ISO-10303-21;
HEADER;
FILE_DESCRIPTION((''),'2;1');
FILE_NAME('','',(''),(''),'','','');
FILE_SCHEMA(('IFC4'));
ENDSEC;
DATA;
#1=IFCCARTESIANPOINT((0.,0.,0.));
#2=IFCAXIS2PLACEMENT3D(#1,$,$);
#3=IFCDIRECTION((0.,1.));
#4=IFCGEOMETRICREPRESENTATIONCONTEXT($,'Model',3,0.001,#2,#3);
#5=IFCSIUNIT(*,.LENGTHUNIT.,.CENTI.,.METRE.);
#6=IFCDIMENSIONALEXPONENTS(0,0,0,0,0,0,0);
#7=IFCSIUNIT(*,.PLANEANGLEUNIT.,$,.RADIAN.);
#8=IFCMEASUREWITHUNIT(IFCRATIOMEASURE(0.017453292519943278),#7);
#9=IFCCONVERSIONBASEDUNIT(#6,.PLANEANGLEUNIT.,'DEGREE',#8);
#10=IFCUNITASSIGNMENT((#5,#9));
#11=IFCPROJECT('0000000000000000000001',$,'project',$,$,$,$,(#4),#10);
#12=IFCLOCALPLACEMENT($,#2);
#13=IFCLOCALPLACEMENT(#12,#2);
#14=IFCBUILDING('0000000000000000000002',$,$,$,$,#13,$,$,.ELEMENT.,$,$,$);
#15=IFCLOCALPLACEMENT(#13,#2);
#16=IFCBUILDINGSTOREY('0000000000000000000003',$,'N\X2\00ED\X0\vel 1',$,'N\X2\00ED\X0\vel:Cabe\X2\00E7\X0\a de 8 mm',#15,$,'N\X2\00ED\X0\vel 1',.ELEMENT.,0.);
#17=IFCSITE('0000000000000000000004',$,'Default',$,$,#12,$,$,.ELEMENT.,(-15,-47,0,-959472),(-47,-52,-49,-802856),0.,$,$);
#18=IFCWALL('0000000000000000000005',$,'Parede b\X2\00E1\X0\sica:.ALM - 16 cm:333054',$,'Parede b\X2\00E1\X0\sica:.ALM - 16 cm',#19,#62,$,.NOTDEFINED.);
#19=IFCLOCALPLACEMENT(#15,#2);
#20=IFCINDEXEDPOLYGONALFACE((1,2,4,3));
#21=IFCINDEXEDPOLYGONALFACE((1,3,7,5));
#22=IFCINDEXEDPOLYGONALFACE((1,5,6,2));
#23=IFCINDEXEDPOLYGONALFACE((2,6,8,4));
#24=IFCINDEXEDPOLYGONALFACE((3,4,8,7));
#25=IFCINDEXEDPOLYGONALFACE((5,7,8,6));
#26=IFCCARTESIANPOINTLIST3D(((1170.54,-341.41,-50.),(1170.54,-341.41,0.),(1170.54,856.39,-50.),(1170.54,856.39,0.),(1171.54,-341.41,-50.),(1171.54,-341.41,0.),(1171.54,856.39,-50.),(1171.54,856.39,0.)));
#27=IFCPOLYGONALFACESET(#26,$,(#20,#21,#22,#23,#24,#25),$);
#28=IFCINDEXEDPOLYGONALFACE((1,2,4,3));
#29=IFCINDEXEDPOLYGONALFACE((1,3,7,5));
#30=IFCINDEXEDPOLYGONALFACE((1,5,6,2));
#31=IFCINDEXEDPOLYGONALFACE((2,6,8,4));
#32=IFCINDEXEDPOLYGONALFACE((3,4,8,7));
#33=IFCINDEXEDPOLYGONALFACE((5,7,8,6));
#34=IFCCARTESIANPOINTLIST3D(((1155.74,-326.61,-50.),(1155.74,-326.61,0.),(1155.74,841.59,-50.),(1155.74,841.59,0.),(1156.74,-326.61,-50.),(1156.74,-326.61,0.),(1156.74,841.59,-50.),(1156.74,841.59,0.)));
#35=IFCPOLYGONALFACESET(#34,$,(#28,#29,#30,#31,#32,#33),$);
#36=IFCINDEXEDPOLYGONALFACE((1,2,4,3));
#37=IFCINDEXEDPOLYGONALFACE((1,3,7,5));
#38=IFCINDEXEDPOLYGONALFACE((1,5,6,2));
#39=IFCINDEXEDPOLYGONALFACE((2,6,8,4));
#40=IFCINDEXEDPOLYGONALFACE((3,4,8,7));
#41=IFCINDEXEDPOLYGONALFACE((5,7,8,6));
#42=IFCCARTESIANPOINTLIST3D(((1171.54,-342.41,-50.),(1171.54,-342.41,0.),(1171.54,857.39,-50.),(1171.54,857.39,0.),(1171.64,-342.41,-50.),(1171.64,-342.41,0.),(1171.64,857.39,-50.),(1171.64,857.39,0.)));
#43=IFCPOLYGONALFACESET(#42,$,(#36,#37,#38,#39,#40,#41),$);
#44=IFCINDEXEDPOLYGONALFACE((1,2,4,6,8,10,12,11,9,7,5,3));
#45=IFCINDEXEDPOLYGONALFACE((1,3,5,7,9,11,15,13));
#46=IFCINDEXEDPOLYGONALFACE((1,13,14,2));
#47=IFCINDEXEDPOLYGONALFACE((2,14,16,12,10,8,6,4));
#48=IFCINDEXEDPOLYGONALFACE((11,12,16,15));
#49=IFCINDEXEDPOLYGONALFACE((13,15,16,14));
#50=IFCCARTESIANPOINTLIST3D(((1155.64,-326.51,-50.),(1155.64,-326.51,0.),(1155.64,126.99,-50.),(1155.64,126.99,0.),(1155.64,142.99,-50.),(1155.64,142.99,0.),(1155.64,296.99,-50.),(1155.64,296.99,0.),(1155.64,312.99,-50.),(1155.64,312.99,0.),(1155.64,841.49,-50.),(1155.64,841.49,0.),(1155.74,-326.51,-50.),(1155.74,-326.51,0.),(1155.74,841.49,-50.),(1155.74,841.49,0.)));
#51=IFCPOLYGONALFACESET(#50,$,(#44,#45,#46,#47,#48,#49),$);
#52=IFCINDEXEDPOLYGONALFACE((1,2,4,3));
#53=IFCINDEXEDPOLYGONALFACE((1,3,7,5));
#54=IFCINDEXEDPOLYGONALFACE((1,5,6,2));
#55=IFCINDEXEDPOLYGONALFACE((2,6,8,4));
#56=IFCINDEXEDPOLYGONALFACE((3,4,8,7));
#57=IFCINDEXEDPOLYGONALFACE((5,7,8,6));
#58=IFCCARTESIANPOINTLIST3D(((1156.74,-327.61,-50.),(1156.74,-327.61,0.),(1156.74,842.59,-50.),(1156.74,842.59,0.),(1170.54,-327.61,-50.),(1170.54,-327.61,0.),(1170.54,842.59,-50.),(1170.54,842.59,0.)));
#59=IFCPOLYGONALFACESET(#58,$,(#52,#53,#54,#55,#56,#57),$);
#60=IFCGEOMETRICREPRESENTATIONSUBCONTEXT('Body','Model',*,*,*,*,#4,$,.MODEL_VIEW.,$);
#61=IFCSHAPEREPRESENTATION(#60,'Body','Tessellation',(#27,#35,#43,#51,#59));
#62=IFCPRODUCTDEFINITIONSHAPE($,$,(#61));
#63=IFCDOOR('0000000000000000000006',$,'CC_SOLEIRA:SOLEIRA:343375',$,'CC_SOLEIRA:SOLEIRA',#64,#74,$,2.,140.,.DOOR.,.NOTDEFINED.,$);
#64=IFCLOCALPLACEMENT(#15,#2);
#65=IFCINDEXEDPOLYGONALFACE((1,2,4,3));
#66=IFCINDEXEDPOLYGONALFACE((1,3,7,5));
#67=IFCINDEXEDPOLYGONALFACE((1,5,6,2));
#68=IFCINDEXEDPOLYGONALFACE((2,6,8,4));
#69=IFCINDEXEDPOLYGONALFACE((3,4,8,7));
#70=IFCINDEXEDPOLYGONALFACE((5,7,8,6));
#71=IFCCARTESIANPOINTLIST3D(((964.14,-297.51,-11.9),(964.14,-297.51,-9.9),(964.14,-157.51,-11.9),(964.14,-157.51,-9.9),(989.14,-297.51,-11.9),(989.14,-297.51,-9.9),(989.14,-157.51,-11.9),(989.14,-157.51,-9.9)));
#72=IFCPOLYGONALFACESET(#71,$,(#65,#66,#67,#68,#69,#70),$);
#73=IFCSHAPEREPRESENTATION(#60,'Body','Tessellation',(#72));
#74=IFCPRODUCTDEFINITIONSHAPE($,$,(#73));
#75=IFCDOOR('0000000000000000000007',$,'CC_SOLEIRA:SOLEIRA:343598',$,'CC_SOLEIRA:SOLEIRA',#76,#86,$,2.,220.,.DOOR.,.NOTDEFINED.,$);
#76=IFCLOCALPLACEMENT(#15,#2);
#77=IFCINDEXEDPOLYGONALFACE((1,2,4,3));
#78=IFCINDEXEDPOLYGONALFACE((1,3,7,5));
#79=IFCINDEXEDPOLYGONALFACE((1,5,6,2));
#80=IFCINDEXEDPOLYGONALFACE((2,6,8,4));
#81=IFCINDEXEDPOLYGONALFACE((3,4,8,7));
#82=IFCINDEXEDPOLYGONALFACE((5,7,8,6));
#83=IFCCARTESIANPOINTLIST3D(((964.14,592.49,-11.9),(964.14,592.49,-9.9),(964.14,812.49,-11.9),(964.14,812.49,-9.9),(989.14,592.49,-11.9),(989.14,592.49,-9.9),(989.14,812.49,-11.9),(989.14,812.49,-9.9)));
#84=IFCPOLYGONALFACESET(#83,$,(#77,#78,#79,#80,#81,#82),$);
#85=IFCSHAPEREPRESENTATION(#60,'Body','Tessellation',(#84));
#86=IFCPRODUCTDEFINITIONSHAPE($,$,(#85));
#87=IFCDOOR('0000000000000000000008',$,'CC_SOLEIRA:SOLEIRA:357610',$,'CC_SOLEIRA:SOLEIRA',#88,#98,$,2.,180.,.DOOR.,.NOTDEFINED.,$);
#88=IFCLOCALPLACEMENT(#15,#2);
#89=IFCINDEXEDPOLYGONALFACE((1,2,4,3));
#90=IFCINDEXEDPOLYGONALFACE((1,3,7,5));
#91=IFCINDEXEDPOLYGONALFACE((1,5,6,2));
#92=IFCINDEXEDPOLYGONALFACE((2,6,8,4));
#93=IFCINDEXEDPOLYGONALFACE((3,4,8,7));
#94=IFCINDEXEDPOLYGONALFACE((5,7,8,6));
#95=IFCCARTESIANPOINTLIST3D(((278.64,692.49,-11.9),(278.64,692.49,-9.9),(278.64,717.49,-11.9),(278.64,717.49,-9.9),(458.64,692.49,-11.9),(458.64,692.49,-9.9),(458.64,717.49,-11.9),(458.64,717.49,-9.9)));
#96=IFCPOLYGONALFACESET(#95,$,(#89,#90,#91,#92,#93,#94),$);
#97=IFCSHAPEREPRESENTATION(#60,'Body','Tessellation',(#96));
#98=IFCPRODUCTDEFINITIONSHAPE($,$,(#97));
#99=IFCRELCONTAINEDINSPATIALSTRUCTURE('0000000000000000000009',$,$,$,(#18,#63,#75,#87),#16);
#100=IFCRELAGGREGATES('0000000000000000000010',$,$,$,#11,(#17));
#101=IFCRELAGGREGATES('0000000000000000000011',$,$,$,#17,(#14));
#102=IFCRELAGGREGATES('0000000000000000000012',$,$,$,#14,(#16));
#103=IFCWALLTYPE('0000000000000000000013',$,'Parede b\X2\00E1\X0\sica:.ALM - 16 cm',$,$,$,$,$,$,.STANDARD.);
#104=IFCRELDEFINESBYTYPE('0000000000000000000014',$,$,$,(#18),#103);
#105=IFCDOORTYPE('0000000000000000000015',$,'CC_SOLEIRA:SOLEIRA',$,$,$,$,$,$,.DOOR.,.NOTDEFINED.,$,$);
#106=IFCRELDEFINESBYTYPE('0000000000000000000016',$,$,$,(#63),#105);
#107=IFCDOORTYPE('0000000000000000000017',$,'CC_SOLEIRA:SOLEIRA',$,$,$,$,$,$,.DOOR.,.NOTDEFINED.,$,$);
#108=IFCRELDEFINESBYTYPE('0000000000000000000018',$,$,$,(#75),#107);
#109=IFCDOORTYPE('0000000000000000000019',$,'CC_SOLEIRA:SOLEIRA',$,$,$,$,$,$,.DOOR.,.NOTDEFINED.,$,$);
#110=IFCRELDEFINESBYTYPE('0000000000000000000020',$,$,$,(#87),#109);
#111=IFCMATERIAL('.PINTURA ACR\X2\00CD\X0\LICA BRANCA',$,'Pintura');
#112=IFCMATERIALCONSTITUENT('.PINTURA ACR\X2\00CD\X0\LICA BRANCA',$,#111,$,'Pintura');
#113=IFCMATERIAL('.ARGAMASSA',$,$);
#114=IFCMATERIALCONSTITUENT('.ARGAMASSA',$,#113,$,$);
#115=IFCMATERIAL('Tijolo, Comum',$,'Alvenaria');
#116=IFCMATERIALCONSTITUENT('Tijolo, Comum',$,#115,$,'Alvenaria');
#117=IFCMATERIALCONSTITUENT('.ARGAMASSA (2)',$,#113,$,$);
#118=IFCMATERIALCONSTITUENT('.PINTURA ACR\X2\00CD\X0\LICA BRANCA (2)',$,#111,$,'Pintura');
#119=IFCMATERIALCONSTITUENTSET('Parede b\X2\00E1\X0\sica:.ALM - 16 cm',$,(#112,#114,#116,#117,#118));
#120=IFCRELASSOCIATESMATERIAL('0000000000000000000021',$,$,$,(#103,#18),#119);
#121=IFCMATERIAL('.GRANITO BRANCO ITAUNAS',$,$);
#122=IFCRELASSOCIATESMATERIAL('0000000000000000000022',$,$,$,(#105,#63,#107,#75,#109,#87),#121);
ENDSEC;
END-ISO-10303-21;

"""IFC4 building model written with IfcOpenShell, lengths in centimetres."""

from ifc_helpers import new_model, entity, si_unit, converted_unit, direction, frame, origin, place, context, subcontext, project, spatial, indexed_curve, outline, extrude, source, transform, mapped, material, constituent, constituent_set, type_object, type_shapes, element, save


model = new_model("IFC4")

# Units and contexts
model_context = context("Model", 3, precision=0.001, world=origin(), true_north=direction((0.0, 1.0)))
body_context = subcontext(model_context, "Body", "Model", "MODEL_VIEW")
ifc_project = project(units=[si_unit("LENGTHUNIT", "METRE", prefix="CENTI"), converted_unit("PLANEANGLEUNIT", "DEGREE", entity("IfcRatioMeasure", 0.017453292519943278), si_unit("PLANEANGLEUNIT", "RADIAN"), dimensions=[0, 0, 0, 0, 0, 0, 0])], contexts=[model_context])

# Site, building, storey
site_placement = place(None, origin())
site = spatial("IfcSite", under=ifc_project, at=site_placement, Name="Default", CompositionType="ELEMENT", RefLatitude=(-15, -47, 0, -959472), RefLongitude=(-47, -52, -49, -802856), RefElevation=0.0)
building_placement = place(site_placement, origin())
building = spatial("IfcBuilding", under=site, at=building_placement, CompositionType="ELEMENT")
storey_placement = place(building_placement, origin())
storey = spatial("IfcBuildingStorey", under=building, at=storey_placement, Name="Nível 1", ObjectType="Nível:Cabeça de 8 mm", LongName="Nível 1", CompositionType="ELEMENT", Elevation=0.0)

# Shared definitions
ifc_material_1 = material(Name=".PINTURA ACRÍLICA BRANCA", Category="Pintura")
ifc_material_2 = material(Name=".ARGAMASSA")
ifc_material_3 = material(Name="Tijolo, Comum", Category="Alvenaria")

# Shared definitions
ifc_constituent_1 = constituent(ifc_material_1, Name=".PINTURA ACRÍLICA BRANCA", Category="Pintura")
ifc_constituent_2 = constituent(ifc_material_2, Name=".ARGAMASSA")
ifc_constituent_3 = constituent(ifc_material_3, Name="Tijolo, Comum", Category="Alvenaria")
ifc_constituent_4 = constituent(ifc_material_2, Name=".ARGAMASSA (2)")
ifc_constituent_5 = constituent(ifc_material_1, Name=".PINTURA ACRÍLICA BRANCA (2)", Category="Pintura")
ifc_constituent_set_1 = constituent_set(constituents=[ifc_constituent_1, ifc_constituent_2, ifc_constituent_3, ifc_constituent_4, ifc_constituent_5], Name="Parede básica:.ALM - 16 cm")
wall_type_1 = type_object("IfcWallType", Name="Parede básica:.ALM - 16 cm", PredefinedType="STANDARD", material=ifc_constituent_set_1)

# Wall
wall_1_placement = place(storey_placement, frame((1163.64, -326.51, -50.0), z_axis=(0.0, 0.0, 1.0), x_axis=(0.0, 1.0, 0.0)))
element("IfcWall", 1, at=wall_1_placement, inside=storey, type_object=wall_type_1, material=ifc_constituent_set_1, Name="Parede básica:.ALM - 16 cm:333054", ObjectType="Parede básica:.ALM - 16 cm", PredefinedType="NOTDEFINED", context=body_context, shape_type="SweptSolid", body=[
    extrude(outline(indexed_curve([(-598.9, -0.5), (598.9, -0.5), (598.9, 0.5), (-598.9, 0.5), (-598.9, -0.5)], self_intersect=False)), frame((584.0, -7.4, 0.0)), (0.0, 0.0, 1.0), 50.0),
    extrude(outline(indexed_curve([(-584.1, -0.5), (584.1, -0.5), (584.1, 0.5), (-584.1, 0.5), (-584.1, -0.5)], self_intersect=False)), frame((584.0, 7.4, 0.0)), (0.0, 0.0, 1.0), 50.0),
    extrude(outline(indexed_curve([(-0.05, -599.9), (0.05, -599.9), (0.05, 599.9), (-0.05, 599.9), (-0.05, -599.9)], self_intersect=False)), frame((584.0, -7.95, 0.0), z_axis=(0.0, 0.0, 1.0), x_axis=(0.0, 1.0, 0.0)), (0.0, 0.0, 1.0), 50.0),
    extrude(outline(indexed_curve([(-74.25, -0.02), (-58.25, -0.02), (95.75, -0.02), (111.75, -0.02), (565.25, -0.03), (565.25, 0.07), (-602.75, 0.08), (-602.75, -0.02), (-74.25, -0.02)], self_intersect=False)), frame((565.25, 7.98, 0.0), z_axis=(0.0, 0.0, 1.0), x_axis=(-1.0, 0.0, 0.0)), (0.0, 0.0, 1.0), 50.0),
    extrude(outline(indexed_curve([(-585.1, -6.9), (585.1, -6.9), (585.1, 6.9), (-585.1, 6.9), (-585.1, -6.9)], self_intersect=False)), frame((584.0, 0.0, 0.0)), (0.0, 0.0, 1.0), 50.0),
])

# Doors
ifc_material_4 = material(Name=".GRANITO BRANCO ITAUNAS")
door_type_1 = type_object("IfcDoorType", Name="CC_SOLEIRA:SOLEIRA", OperationType="NOTDEFINED", PredefinedType="DOOR", material=ifc_material_4)
shared_shape_1 = source(origin(), body_context, "Body", "SweptSolid", [
    extrude(outline(indexed_curve([(-12.5, -70.0), (12.5, -70.0), (12.5, 70.0), (-12.5, 70.0), (-12.5, -70.0)], self_intersect=False)), frame((70.0, 12.5, 0.0), z_axis=(0.0, 0.0, 1.0), x_axis=(0.0, -1.0, 0.0)), (0.0, 0.0, 1.0), 2.0),
])
type_shapes(door_type_1, [shared_shape_1])
door_1_placement = place(storey_placement, frame((964.14, -157.51, -11.9), z_axis=(0.0, 0.0, 1.0), x_axis=(0.0, -1.0, 0.0)))
element("IfcDoor", 2, at=door_1_placement, inside=storey, type_object=door_type_1, material=ifc_material_4, Name="CC_SOLEIRA:SOLEIRA:343375", ObjectType="CC_SOLEIRA:SOLEIRA", OperationType="NOTDEFINED", OverallHeight=2.0, OverallWidth=140.0, PredefinedType="DOOR", context=body_context, shape_type="MappedRepresentation", body=[
    mapped(shared_shape_1, transform((0.0, 0.0, 0.0), scale=1.0)),
])
door_type_2 = type_object("IfcDoorType", Name="CC_SOLEIRA:SOLEIRA", OperationType="NOTDEFINED", PredefinedType="DOOR", material=ifc_material_4)
shared_shape_2 = source(origin(), body_context, "Body", "SweptSolid", [
    extrude(outline(indexed_curve([(-110.0, -12.5), (110.0, -12.5), (110.0, 12.5), (-110.0, 12.5), (-110.0, -12.5)], self_intersect=False)), frame((110.0, 12.5, 0.0), z_axis=(0.0, 0.0, 1.0), x_axis=(-1.0, 0.0, 0.0)), (0.0, 0.0, 1.0), 2.0),
])
type_shapes(door_type_2, [shared_shape_2])
door_2_placement = place(storey_placement, frame((964.14, 812.49, -11.9), z_axis=(0.0, 0.0, 1.0), x_axis=(0.0, -1.0, 0.0)))
element("IfcDoor", 3, at=door_2_placement, inside=storey, type_object=door_type_2, material=ifc_material_4, Name="CC_SOLEIRA:SOLEIRA:343598", ObjectType="CC_SOLEIRA:SOLEIRA", OperationType="NOTDEFINED", OverallHeight=2.0, OverallWidth=220.0, PredefinedType="DOOR", context=body_context, shape_type="MappedRepresentation", body=[
    mapped(shared_shape_2, transform((0.0, 0.0, 0.0), scale=1.0)),
])
door_type_3 = type_object("IfcDoorType", Name="CC_SOLEIRA:SOLEIRA", OperationType="NOTDEFINED", PredefinedType="DOOR", material=ifc_material_4)
shared_shape_3 = source(origin(), body_context, "Body", "SweptSolid", [
    extrude(outline(indexed_curve([(-90.0, -12.5), (90.0, -12.5), (90.0, 12.5), (-90.0, 12.5), (-90.0, -12.5)], self_intersect=False)), frame((90.0, 12.5, 0.0), z_axis=(0.0, 0.0, 1.0), x_axis=(-1.0, 0.0, 0.0)), (0.0, 0.0, 1.0), 2.0),
])
type_shapes(door_type_3, [shared_shape_3])
door_3_placement = place(storey_placement, frame((278.64, 692.49, -11.9)))
element("IfcDoor", 4, at=door_3_placement, inside=storey, type_object=door_type_3, material=ifc_material_4, Name="CC_SOLEIRA:SOLEIRA:357610", ObjectType="CC_SOLEIRA:SOLEIRA", OperationType="NOTDEFINED", OverallHeight=2.0, OverallWidth=180.0, PredefinedType="DOOR", context=body_context, shape_type="MappedRepresentation", body=[
    mapped(shared_shape_3, transform((0.0, 0.0, 0.0), scale=1.0)),
])

save(model, "model.ifc")
